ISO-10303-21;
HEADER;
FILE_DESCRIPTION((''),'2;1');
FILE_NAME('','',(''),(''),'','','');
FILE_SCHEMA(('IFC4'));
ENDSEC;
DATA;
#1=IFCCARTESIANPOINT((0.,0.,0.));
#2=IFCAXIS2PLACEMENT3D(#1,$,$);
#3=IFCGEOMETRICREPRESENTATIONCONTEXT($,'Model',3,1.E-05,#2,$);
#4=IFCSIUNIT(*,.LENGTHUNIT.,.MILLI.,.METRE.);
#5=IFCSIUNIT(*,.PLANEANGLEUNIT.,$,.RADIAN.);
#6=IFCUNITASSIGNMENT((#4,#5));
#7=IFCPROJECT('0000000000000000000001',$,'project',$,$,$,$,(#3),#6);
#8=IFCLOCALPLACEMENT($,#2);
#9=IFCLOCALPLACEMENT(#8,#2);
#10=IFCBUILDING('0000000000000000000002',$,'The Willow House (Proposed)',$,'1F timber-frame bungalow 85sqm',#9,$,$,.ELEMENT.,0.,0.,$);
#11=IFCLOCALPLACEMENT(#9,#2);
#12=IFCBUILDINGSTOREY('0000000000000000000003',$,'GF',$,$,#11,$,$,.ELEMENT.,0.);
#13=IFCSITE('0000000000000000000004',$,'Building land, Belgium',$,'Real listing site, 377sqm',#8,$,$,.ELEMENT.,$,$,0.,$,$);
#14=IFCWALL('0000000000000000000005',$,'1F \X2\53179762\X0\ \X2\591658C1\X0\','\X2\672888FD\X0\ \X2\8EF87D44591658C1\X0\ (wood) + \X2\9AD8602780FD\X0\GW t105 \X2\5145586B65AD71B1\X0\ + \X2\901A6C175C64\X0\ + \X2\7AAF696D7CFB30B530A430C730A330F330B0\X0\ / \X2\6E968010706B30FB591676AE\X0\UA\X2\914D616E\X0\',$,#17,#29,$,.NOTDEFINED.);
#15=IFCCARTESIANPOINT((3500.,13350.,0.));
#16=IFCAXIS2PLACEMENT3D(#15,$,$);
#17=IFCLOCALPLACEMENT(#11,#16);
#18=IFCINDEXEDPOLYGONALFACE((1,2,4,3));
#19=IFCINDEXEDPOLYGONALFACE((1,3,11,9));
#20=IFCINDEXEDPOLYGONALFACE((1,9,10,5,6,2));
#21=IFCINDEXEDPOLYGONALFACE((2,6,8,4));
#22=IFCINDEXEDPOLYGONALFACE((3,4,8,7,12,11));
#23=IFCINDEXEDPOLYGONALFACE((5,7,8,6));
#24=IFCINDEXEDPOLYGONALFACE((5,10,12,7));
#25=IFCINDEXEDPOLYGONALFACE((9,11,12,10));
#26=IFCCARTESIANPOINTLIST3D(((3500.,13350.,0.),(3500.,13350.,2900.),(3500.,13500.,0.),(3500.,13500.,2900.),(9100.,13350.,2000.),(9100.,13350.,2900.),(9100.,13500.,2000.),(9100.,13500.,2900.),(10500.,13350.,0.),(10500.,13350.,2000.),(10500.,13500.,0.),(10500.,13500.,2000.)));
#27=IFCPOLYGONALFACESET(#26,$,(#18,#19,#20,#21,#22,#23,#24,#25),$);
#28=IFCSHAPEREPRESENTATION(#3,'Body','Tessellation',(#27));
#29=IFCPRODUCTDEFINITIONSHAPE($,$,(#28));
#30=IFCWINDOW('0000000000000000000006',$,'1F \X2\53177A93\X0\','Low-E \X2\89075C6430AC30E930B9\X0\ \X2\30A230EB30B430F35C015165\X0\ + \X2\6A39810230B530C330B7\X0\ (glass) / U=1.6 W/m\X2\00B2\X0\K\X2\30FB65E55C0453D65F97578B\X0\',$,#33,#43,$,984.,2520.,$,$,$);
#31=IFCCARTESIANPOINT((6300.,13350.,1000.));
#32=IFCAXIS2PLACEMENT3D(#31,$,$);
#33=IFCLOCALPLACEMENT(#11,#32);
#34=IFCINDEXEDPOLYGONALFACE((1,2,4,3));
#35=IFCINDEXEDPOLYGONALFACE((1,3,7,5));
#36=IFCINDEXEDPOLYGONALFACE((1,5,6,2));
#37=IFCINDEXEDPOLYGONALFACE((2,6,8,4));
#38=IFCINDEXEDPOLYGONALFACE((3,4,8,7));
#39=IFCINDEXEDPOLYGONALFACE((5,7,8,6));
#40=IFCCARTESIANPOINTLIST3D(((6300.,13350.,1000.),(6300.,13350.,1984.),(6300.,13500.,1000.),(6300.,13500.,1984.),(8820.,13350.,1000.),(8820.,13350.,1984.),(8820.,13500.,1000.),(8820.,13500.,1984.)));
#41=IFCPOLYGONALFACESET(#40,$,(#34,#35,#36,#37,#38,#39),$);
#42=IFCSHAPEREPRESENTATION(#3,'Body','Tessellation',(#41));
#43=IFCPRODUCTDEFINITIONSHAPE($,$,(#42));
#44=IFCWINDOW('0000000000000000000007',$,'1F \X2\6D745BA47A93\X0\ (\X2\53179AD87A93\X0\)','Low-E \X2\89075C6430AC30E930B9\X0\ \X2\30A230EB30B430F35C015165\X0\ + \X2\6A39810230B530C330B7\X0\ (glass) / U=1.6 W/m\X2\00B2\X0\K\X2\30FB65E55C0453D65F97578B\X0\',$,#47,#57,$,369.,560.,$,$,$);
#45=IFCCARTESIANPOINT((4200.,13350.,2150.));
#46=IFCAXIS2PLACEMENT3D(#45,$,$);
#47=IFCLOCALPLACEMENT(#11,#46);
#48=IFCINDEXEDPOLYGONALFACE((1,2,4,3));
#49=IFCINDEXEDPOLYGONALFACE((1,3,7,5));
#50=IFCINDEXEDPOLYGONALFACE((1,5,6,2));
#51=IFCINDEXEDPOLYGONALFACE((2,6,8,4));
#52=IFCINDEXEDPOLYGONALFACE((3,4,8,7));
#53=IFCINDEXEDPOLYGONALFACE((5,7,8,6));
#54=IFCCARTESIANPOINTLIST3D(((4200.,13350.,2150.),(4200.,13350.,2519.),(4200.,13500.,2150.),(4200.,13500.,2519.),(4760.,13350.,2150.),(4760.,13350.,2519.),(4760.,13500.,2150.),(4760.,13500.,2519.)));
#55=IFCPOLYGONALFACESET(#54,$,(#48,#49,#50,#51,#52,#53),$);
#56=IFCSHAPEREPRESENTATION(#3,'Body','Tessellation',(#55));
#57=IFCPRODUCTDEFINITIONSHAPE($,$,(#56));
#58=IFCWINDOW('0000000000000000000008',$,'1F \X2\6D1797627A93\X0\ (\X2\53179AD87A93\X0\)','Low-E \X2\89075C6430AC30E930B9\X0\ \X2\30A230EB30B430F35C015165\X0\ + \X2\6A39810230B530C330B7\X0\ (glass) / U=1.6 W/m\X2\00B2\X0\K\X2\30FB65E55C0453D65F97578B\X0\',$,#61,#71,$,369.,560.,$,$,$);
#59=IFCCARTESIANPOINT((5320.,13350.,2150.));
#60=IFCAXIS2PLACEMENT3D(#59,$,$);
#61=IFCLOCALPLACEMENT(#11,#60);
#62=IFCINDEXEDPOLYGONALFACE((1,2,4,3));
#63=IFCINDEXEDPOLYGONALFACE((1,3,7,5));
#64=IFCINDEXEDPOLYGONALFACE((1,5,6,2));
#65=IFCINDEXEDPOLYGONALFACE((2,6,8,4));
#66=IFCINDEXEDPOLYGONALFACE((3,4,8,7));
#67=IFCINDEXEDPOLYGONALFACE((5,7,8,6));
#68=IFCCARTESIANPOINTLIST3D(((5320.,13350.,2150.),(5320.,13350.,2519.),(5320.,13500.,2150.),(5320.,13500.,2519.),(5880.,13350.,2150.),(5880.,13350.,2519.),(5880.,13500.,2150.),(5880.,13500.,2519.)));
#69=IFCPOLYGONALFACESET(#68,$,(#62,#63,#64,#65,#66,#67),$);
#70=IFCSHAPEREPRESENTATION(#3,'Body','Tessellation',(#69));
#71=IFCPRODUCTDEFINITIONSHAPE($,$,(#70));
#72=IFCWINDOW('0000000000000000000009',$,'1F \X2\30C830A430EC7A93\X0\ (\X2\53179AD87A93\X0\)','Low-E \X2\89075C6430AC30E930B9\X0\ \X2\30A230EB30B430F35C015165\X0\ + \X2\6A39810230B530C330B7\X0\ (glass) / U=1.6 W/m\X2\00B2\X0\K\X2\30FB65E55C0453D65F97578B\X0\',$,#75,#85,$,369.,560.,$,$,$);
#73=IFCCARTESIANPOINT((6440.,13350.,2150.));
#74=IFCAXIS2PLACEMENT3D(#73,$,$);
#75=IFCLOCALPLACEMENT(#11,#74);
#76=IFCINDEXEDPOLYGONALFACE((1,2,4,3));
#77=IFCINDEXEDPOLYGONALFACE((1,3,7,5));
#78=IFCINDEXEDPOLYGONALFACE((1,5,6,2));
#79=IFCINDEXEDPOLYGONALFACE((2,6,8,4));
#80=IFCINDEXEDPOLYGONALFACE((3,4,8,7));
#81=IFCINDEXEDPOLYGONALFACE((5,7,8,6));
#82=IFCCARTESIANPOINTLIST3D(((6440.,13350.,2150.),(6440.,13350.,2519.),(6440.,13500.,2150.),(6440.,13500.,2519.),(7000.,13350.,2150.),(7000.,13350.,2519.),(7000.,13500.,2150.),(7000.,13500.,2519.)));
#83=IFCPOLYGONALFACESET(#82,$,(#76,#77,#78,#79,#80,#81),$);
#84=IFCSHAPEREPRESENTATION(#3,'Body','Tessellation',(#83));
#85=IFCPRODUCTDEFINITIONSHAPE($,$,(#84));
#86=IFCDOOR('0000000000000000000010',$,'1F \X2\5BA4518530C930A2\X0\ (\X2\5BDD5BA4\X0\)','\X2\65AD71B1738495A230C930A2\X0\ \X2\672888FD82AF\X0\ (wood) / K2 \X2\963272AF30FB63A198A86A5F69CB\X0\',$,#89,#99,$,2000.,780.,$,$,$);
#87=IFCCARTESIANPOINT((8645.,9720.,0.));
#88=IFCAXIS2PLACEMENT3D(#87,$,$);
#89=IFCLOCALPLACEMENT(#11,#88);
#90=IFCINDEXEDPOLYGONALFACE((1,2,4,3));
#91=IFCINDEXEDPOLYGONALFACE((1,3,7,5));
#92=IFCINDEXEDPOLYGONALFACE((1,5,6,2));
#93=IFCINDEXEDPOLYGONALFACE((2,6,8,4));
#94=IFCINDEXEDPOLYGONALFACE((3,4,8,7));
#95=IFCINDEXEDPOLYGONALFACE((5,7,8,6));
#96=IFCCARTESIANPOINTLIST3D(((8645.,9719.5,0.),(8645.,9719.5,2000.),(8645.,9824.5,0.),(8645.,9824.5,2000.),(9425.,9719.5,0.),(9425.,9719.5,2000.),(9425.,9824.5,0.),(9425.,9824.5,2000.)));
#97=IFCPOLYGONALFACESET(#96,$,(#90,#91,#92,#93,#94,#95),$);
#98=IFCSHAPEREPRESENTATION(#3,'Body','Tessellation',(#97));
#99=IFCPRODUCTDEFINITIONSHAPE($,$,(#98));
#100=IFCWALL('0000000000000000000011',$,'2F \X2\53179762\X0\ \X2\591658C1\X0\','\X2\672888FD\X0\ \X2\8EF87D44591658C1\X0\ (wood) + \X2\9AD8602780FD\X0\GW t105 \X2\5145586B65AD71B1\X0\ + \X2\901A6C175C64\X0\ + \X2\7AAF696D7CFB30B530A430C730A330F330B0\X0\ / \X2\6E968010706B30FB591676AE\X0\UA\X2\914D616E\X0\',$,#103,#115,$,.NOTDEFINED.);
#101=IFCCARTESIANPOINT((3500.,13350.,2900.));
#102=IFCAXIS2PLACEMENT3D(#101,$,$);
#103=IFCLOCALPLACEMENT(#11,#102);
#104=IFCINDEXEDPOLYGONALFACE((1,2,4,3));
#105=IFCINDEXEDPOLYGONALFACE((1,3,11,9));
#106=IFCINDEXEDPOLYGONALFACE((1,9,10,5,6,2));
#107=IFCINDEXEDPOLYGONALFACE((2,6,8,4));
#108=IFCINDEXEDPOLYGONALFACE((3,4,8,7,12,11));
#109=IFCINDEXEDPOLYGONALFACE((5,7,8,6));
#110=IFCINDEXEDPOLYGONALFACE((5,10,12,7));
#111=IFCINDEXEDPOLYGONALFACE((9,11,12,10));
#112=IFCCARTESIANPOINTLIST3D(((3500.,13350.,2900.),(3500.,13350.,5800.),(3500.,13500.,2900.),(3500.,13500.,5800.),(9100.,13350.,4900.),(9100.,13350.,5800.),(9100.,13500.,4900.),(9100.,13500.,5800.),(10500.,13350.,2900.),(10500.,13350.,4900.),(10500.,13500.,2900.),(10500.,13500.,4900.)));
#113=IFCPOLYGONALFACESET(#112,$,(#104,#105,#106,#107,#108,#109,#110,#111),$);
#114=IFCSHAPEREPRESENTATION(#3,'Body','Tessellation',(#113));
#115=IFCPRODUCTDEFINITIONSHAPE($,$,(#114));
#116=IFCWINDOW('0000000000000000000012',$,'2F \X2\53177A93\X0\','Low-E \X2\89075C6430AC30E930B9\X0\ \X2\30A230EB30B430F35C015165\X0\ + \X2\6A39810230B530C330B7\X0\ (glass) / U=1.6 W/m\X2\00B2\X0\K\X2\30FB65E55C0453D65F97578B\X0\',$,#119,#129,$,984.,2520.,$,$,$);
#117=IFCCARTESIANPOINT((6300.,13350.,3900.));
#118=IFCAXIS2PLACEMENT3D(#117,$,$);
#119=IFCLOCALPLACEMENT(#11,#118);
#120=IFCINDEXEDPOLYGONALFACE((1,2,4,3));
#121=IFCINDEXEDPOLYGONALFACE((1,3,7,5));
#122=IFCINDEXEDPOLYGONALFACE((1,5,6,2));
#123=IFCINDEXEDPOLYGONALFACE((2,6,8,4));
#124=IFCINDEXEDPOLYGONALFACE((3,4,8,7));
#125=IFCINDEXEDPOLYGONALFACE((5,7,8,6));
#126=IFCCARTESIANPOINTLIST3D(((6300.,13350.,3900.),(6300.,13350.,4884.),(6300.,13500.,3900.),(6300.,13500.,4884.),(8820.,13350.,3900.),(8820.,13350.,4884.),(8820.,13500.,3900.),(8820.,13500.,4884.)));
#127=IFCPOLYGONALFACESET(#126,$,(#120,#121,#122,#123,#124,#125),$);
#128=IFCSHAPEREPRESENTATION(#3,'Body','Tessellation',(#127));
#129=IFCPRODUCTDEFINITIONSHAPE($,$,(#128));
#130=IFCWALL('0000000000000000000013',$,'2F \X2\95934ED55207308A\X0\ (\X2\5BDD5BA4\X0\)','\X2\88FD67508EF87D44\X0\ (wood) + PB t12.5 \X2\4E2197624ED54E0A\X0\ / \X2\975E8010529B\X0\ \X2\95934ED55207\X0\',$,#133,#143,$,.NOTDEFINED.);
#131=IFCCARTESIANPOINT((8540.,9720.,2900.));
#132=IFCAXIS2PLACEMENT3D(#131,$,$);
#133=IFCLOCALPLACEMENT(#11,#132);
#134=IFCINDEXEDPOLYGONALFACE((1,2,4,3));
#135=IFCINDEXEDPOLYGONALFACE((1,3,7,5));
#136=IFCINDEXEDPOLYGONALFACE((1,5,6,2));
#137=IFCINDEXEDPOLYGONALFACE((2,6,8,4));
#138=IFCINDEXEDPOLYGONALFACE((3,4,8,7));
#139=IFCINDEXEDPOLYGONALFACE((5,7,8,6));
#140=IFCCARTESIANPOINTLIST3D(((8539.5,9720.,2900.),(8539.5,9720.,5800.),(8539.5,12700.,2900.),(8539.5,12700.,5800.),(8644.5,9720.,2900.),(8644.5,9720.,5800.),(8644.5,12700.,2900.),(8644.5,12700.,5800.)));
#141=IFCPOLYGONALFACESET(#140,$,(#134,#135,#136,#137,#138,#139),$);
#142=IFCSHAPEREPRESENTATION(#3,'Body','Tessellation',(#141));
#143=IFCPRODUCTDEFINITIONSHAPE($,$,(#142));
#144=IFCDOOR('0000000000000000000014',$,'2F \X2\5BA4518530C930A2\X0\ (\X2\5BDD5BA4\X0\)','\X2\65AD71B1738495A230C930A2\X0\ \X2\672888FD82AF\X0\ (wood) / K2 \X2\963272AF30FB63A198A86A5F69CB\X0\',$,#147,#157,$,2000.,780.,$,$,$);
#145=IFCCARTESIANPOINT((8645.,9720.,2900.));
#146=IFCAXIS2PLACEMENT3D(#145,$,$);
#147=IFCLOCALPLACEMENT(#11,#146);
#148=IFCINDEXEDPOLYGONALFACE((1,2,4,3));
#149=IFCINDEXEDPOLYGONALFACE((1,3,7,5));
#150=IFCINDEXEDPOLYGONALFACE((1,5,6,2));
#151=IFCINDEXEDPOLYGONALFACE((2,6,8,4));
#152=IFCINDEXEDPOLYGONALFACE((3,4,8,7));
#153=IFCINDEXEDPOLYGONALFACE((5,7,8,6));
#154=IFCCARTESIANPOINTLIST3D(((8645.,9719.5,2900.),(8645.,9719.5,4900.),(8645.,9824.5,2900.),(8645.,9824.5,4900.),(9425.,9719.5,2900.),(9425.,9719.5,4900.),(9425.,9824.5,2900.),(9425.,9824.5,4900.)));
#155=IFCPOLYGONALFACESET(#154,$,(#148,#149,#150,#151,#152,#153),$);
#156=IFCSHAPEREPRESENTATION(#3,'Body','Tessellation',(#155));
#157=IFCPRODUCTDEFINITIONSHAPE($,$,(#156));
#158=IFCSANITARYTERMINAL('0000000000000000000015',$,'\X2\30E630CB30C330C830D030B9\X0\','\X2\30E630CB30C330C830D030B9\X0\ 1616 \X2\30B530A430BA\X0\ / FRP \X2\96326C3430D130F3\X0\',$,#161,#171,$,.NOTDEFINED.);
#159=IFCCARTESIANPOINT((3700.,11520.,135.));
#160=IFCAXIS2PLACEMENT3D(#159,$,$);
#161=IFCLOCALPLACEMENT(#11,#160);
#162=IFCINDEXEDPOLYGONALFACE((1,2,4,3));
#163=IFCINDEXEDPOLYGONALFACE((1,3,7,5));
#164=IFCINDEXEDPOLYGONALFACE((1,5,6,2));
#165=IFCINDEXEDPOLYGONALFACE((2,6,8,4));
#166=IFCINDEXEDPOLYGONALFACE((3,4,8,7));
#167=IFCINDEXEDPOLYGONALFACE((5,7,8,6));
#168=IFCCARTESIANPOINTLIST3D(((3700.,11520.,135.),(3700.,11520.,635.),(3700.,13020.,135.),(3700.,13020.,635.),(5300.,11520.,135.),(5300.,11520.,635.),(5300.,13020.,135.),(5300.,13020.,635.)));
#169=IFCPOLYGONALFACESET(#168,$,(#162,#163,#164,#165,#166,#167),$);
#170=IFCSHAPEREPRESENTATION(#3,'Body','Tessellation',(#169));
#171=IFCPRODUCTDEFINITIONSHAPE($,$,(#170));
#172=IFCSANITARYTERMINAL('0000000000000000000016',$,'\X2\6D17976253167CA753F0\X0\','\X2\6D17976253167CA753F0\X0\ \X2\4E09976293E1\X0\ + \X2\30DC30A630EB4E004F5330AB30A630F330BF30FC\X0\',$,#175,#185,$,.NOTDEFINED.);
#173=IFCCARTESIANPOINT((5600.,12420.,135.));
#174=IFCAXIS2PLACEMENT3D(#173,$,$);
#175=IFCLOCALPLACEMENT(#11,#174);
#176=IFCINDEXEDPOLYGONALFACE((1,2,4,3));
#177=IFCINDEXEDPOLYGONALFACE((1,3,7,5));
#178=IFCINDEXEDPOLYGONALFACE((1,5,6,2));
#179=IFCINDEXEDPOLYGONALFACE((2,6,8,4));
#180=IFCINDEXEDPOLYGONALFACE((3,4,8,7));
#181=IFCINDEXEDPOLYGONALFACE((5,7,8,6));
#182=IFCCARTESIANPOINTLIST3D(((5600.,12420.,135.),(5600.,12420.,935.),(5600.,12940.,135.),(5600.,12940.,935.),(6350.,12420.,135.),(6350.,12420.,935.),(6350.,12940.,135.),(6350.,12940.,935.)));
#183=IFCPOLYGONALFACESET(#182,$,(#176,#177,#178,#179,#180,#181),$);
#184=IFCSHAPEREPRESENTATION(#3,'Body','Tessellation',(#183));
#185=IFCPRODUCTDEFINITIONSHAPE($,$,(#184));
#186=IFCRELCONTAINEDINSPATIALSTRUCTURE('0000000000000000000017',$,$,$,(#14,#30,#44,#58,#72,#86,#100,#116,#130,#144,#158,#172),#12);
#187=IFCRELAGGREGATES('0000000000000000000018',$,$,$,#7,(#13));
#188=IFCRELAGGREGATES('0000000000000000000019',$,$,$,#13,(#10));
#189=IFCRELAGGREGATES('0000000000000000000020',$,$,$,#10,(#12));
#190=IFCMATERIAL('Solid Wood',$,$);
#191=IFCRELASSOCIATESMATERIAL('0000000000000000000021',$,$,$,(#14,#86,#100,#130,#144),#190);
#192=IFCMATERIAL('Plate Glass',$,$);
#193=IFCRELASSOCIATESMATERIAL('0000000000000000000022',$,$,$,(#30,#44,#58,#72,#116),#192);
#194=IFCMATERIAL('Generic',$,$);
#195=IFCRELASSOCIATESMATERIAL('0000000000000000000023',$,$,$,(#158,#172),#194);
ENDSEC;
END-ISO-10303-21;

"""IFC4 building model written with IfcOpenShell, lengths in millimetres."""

from ifc_helpers import new_model, si_unit, frame, frame_2d, origin, place, context, project, spatial, rectangle, extrude, material, element, fill, save


model = new_model("IFC4")

# Units and contexts
model_context = context("Model", 3, precision=1e-05, world=origin())
ifc_project = project(units=[si_unit("LENGTHUNIT", "METRE", prefix="MILLI"), si_unit("PLANEANGLEUNIT", "RADIAN")], contexts=[model_context])

# Site, building, storey
site_placement = place(None, origin())
site = spatial("IfcSite", under=ifc_project, at=site_placement, Name="Building land, Belgium", ObjectType="Real listing site, 377sqm", CompositionType="ELEMENT", RefElevation=0.0)
building_placement = place(site_placement, origin())
building = spatial("IfcBuilding", under=site, at=building_placement, Name="The Willow House (Proposed)", ObjectType="1F timber-frame bungalow 85sqm", CompositionType="ELEMENT", ElevationOfRefHeight=0.0, ElevationOfTerrain=0.0)
storey_placement = place(building_placement, origin())
storey = spatial("IfcBuildingStorey", under=building, at=storey_placement, Name="GF", CompositionType="ELEMENT", Elevation=0.0)

# Wall, openings, windows
ifc_material_1 = material(Name="Solid Wood")
wall_1_placement = place(storey_placement, frame((3500.0, 13350.0, 0.0)))
wall_1 = element("IfcWall", 1, at=wall_1_placement, inside=storey, material=ifc_material_1, Name="1F 北面 外壁", Description="木製 軸組外壁 (wood) + 高性能GW t105 充填断熱 + 通気層 + 窯業系サイディング / 準耐火・外皮UA配慮", PredefinedType="NOTDEFINED", context=model_context, shape_type="SweptSolid", body=[
    extrude(rectangle(XDim=7000.0, YDim=150.0, at=frame_2d((3500.0, 75.0))), frame((3500.0, 13350.0, 0.0)), (0.0, 0.0, 1.0), 2900.0),
])
opening_1_placement = place(storey_placement, frame((6300.0, 13350.0, 1000.0)))
opening_1 = element("IfcOpeningElement", 2, at=opening_1_placement, cuts=wall_1, PredefinedType="NOTDEFINED", context=model_context, shape_type="SweptSolid", body=[
    extrude(rectangle(XDim=2520.0, YDim=150.0, at=frame_2d((1260.0, 75.0))), frame((6300.0, 13350.0, 1000.0)), (0.0, 0.0, 1.0), 984.0),
])
opening_2_placement = place(storey_placement, frame((4200.0, 13350.0, 2150.0)))
opening_2 = element("IfcOpeningElement", 3, at=opening_2_placement, cuts=wall_1, PredefinedType="NOTDEFINED", context=model_context, shape_type="SweptSolid", body=[
    extrude(rectangle(XDim=560.0, YDim=150.0, at=frame_2d((280.0, 75.0))), frame((4200.0, 13350.0, 2150.0)), (0.0, 0.0, 1.0), 369.0),
])
opening_3_placement = place(storey_placement, frame((5320.0, 13350.0, 2150.0)))
opening_3 = element("IfcOpeningElement", 4, at=opening_3_placement, cuts=wall_1, PredefinedType="NOTDEFINED", context=model_context, shape_type="SweptSolid", body=[
    extrude(rectangle(XDim=560.0, YDim=150.0, at=frame_2d((280.0, 75.0))), frame((5320.0, 13350.0, 2150.0)), (0.0, 0.0, 1.0), 369.0),
])
opening_4_placement = place(storey_placement, frame((6440.0, 13350.0, 2150.0)))
opening_4 = element("IfcOpeningElement", 5, at=opening_4_placement, cuts=wall_1, PredefinedType="NOTDEFINED", context=model_context, shape_type="SweptSolid", body=[
    extrude(rectangle(XDim=560.0, YDim=150.0, at=frame_2d((280.0, 75.0))), frame((6440.0, 13350.0, 2150.0)), (0.0, 0.0, 1.0), 369.0),
])
ifc_material_2 = material(Name="Plate Glass")
window_1_placement = place(storey_placement, frame((6300.0, 13350.0, 1000.0)))
window_1 = element("IfcWindow", 6, at=window_1_placement, inside=storey, material=ifc_material_2, Name="1F 北窓", Description="Low-E 複層ガラス アルゴン封入 + 樹脂サッシ (glass) / U=1.6 W/m²K・日射取得型", OverallHeight=984.0, OverallWidth=2520.0, context=model_context, shape_type="SweptSolid", body=[
    extrude(rectangle(XDim=2520.0, YDim=150.0, at=frame_2d((1260.0, 75.0))), frame((6300.0, 13350.0, 1000.0)), (0.0, 0.0, 1.0), 984.0),
])
fill(opening_1, window_1)
window_2_placement = place(storey_placement, frame((4200.0, 13350.0, 2150.0)))
window_2 = element("IfcWindow", 7, at=window_2_placement, inside=storey, material=ifc_material_2, Name="1F 浴室窓 (北高窓)", Description="Low-E 複層ガラス アルゴン封入 + 樹脂サッシ (glass) / U=1.6 W/m²K・日射取得型", OverallHeight=369.0, OverallWidth=560.0, context=model_context, shape_type="SweptSolid", body=[
    extrude(rectangle(XDim=560.0, YDim=150.0, at=frame_2d((280.0, 75.0))), frame((4200.0, 13350.0, 2150.0)), (0.0, 0.0, 1.0), 369.0),
])
fill(opening_2, window_2)
window_3_placement = place(storey_placement, frame((5320.0, 13350.0, 2150.0)))
window_3 = element("IfcWindow", 8, at=window_3_placement, inside=storey, material=ifc_material_2, Name="1F 洗面窓 (北高窓)", Description="Low-E 複層ガラス アルゴン封入 + 樹脂サッシ (glass) / U=1.6 W/m²K・日射取得型", OverallHeight=369.0, OverallWidth=560.0, context=model_context, shape_type="SweptSolid", body=[
    extrude(rectangle(XDim=560.0, YDim=150.0, at=frame_2d((280.0, 75.0))), frame((5320.0, 13350.0, 2150.0)), (0.0, 0.0, 1.0), 369.0),
])
fill(opening_3, window_3)
window_4_placement = place(storey_placement, frame((6440.0, 13350.0, 2150.0)))
window_4 = element("IfcWindow", 9, at=window_4_placement, inside=storey, material=ifc_material_2, Name="1F トイレ窓 (北高窓)", Description="Low-E 複層ガラス アルゴン封入 + 樹脂サッシ (glass) / U=1.6 W/m²K・日射取得型", OverallHeight=369.0, OverallWidth=560.0, context=model_context, shape_type="SweptSolid", body=[
    extrude(rectangle(XDim=560.0, YDim=150.0, at=frame_2d((280.0, 75.0))), frame((6440.0, 13350.0, 2150.0)), (0.0, 0.0, 1.0), 369.0),
])
fill(opening_4, window_4)

# Door
door_1_placement = place(storey_placement, frame((8645.0, 9720.0, 0.0)))
element("IfcDoor", 10, at=door_1_placement, inside=storey, material=ifc_material_1, Name="1F 室内ドア (寝室)", Description="断熱玄関ドア 木製芯 (wood) / K2 防犯・採風機構", OverallHeight=2000.0, OverallWidth=780.0, context=model_context, shape_type="SweptSolid", body=[
    extrude(rectangle(XDim=780.0, YDim=105.0, at=frame_2d((390.0, 52.0))), frame((8645.0, 9720.0, 0.0)), (0.0, 0.0, 1.0), 2000.0),
])

# Wall, opening, window
wall_2_placement = place(storey_placement, frame((3500.0, 13350.0, 2900.0)))
wall_2 = element("IfcWall", 11, at=wall_2_placement, inside=storey, material=ifc_material_1, Name="2F 北面 外壁", Description="木製 軸組外壁 (wood) + 高性能GW t105 充填断熱 + 通気層 + 窯業系サイディング / 準耐火・外皮UA配慮", PredefinedType="NOTDEFINED", context=model_context, shape_type="SweptSolid", body=[
    extrude(rectangle(XDim=7000.0, YDim=150.0, at=frame_2d((3500.0, 75.0))), frame((3500.0, 13350.0, 2900.0)), (0.0, 0.0, 1.0), 2900.0),
])
opening_5_placement = place(storey_placement, frame((6300.0, 13350.0, 3900.0)))
opening_5 = element("IfcOpeningElement", 12, at=opening_5_placement, cuts=wall_2, PredefinedType="NOTDEFINED", context=model_context, shape_type="SweptSolid", body=[
    extrude(rectangle(XDim=2520.0, YDim=150.0, at=frame_2d((1260.0, 75.0))), frame((6300.0, 13350.0, 3900.0)), (0.0, 0.0, 1.0), 984.0),
])
window_5_placement = place(storey_placement, frame((6300.0, 13350.0, 3900.0)))
window_5 = element("IfcWindow", 13, at=window_5_placement, inside=storey, material=ifc_material_2, Name="2F 北窓", Description="Low-E 複層ガラス アルゴン封入 + 樹脂サッシ (glass) / U=1.6 W/m²K・日射取得型", OverallHeight=984.0, OverallWidth=2520.0, context=model_context, shape_type="SweptSolid", body=[
    extrude(rectangle(XDim=2520.0, YDim=150.0, at=frame_2d((1260.0, 75.0))), frame((6300.0, 13350.0, 3900.0)), (0.0, 0.0, 1.0), 984.0),
])
fill(opening_5, window_5)

# Wall
wall_3_placement = place(storey_placement, frame((8540.0, 9720.0, 2900.0)))
element("IfcWall", 14, at=wall_3_placement, inside=storey, material=ifc_material_1, Name="2F 間仕切り (寝室)", Description="製材軸組 (wood) + PB t12.5 両面仕上 / 非耐力 間仕切", PredefinedType="NOTDEFINED", context=model_context, shape_type="SweptSolid", body=[
    extrude(rectangle(XDim=105.0, YDim=2980.0, at=frame_2d((52.0, 1490.0))), frame((8540.0, 9720.0, 2900.0)), (0.0, 0.0, 1.0), 2900.0),
])

# Door
door_2_placement = place(storey_placement, frame((8645.0, 9720.0, 2900.0)))
element("IfcDoor", 15, at=door_2_placement, inside=storey, material=ifc_material_1, Name="2F 室内ドア (寝室)", Description="断熱玄関ドア 木製芯 (wood) / K2 防犯・採風機構", OverallHeight=2000.0, OverallWidth=780.0, context=model_context, shape_type="SweptSolid", body=[
    extrude(rectangle(XDim=780.0, YDim=105.0, at=frame_2d((390.0, 52.0))), frame((8645.0, 9720.0, 2900.0)), (0.0, 0.0, 1.0), 2000.0),
])

# Sanitary terminals
ifc_material_3 = material(Name="Generic")
sanitary_terminal_1_placement = place(storey_placement, frame((3700.0, 11520.0, 135.0)))
element("IfcSanitaryTerminal", 16, at=sanitary_terminal_1_placement, inside=storey, material=ifc_material_3, Name="ユニットバス", Description="ユニットバス 1616 サイズ / FRP 防水パン", PredefinedType="NOTDEFINED", context=model_context, shape_type="SweptSolid", body=[
    extrude(rectangle(XDim=1600.0, YDim=1500.0, at=frame_2d((800.0, 750.0))), frame((3700.0, 11520.0, 135.0)), (0.0, 0.0, 1.0), 500.0),
])
sanitary_terminal_2_placement = place(storey_placement, frame((5600.0, 12420.0, 135.0)))
element("IfcSanitaryTerminal", 17, at=sanitary_terminal_2_placement, inside=storey, material=ifc_material_3, Name="洗面化粧台", Description="洗面化粧台 三面鏡 + ボウル一体カウンター", PredefinedType="NOTDEFINED", context=model_context, shape_type="SweptSolid", body=[
    extrude(rectangle(XDim=750.0, YDim=520.0, at=frame_2d((375.0, 260.0))), frame((5600.0, 12420.0, 135.0)), (0.0, 0.0, 1.0), 800.0),
])

save(model, "model.ifc")
